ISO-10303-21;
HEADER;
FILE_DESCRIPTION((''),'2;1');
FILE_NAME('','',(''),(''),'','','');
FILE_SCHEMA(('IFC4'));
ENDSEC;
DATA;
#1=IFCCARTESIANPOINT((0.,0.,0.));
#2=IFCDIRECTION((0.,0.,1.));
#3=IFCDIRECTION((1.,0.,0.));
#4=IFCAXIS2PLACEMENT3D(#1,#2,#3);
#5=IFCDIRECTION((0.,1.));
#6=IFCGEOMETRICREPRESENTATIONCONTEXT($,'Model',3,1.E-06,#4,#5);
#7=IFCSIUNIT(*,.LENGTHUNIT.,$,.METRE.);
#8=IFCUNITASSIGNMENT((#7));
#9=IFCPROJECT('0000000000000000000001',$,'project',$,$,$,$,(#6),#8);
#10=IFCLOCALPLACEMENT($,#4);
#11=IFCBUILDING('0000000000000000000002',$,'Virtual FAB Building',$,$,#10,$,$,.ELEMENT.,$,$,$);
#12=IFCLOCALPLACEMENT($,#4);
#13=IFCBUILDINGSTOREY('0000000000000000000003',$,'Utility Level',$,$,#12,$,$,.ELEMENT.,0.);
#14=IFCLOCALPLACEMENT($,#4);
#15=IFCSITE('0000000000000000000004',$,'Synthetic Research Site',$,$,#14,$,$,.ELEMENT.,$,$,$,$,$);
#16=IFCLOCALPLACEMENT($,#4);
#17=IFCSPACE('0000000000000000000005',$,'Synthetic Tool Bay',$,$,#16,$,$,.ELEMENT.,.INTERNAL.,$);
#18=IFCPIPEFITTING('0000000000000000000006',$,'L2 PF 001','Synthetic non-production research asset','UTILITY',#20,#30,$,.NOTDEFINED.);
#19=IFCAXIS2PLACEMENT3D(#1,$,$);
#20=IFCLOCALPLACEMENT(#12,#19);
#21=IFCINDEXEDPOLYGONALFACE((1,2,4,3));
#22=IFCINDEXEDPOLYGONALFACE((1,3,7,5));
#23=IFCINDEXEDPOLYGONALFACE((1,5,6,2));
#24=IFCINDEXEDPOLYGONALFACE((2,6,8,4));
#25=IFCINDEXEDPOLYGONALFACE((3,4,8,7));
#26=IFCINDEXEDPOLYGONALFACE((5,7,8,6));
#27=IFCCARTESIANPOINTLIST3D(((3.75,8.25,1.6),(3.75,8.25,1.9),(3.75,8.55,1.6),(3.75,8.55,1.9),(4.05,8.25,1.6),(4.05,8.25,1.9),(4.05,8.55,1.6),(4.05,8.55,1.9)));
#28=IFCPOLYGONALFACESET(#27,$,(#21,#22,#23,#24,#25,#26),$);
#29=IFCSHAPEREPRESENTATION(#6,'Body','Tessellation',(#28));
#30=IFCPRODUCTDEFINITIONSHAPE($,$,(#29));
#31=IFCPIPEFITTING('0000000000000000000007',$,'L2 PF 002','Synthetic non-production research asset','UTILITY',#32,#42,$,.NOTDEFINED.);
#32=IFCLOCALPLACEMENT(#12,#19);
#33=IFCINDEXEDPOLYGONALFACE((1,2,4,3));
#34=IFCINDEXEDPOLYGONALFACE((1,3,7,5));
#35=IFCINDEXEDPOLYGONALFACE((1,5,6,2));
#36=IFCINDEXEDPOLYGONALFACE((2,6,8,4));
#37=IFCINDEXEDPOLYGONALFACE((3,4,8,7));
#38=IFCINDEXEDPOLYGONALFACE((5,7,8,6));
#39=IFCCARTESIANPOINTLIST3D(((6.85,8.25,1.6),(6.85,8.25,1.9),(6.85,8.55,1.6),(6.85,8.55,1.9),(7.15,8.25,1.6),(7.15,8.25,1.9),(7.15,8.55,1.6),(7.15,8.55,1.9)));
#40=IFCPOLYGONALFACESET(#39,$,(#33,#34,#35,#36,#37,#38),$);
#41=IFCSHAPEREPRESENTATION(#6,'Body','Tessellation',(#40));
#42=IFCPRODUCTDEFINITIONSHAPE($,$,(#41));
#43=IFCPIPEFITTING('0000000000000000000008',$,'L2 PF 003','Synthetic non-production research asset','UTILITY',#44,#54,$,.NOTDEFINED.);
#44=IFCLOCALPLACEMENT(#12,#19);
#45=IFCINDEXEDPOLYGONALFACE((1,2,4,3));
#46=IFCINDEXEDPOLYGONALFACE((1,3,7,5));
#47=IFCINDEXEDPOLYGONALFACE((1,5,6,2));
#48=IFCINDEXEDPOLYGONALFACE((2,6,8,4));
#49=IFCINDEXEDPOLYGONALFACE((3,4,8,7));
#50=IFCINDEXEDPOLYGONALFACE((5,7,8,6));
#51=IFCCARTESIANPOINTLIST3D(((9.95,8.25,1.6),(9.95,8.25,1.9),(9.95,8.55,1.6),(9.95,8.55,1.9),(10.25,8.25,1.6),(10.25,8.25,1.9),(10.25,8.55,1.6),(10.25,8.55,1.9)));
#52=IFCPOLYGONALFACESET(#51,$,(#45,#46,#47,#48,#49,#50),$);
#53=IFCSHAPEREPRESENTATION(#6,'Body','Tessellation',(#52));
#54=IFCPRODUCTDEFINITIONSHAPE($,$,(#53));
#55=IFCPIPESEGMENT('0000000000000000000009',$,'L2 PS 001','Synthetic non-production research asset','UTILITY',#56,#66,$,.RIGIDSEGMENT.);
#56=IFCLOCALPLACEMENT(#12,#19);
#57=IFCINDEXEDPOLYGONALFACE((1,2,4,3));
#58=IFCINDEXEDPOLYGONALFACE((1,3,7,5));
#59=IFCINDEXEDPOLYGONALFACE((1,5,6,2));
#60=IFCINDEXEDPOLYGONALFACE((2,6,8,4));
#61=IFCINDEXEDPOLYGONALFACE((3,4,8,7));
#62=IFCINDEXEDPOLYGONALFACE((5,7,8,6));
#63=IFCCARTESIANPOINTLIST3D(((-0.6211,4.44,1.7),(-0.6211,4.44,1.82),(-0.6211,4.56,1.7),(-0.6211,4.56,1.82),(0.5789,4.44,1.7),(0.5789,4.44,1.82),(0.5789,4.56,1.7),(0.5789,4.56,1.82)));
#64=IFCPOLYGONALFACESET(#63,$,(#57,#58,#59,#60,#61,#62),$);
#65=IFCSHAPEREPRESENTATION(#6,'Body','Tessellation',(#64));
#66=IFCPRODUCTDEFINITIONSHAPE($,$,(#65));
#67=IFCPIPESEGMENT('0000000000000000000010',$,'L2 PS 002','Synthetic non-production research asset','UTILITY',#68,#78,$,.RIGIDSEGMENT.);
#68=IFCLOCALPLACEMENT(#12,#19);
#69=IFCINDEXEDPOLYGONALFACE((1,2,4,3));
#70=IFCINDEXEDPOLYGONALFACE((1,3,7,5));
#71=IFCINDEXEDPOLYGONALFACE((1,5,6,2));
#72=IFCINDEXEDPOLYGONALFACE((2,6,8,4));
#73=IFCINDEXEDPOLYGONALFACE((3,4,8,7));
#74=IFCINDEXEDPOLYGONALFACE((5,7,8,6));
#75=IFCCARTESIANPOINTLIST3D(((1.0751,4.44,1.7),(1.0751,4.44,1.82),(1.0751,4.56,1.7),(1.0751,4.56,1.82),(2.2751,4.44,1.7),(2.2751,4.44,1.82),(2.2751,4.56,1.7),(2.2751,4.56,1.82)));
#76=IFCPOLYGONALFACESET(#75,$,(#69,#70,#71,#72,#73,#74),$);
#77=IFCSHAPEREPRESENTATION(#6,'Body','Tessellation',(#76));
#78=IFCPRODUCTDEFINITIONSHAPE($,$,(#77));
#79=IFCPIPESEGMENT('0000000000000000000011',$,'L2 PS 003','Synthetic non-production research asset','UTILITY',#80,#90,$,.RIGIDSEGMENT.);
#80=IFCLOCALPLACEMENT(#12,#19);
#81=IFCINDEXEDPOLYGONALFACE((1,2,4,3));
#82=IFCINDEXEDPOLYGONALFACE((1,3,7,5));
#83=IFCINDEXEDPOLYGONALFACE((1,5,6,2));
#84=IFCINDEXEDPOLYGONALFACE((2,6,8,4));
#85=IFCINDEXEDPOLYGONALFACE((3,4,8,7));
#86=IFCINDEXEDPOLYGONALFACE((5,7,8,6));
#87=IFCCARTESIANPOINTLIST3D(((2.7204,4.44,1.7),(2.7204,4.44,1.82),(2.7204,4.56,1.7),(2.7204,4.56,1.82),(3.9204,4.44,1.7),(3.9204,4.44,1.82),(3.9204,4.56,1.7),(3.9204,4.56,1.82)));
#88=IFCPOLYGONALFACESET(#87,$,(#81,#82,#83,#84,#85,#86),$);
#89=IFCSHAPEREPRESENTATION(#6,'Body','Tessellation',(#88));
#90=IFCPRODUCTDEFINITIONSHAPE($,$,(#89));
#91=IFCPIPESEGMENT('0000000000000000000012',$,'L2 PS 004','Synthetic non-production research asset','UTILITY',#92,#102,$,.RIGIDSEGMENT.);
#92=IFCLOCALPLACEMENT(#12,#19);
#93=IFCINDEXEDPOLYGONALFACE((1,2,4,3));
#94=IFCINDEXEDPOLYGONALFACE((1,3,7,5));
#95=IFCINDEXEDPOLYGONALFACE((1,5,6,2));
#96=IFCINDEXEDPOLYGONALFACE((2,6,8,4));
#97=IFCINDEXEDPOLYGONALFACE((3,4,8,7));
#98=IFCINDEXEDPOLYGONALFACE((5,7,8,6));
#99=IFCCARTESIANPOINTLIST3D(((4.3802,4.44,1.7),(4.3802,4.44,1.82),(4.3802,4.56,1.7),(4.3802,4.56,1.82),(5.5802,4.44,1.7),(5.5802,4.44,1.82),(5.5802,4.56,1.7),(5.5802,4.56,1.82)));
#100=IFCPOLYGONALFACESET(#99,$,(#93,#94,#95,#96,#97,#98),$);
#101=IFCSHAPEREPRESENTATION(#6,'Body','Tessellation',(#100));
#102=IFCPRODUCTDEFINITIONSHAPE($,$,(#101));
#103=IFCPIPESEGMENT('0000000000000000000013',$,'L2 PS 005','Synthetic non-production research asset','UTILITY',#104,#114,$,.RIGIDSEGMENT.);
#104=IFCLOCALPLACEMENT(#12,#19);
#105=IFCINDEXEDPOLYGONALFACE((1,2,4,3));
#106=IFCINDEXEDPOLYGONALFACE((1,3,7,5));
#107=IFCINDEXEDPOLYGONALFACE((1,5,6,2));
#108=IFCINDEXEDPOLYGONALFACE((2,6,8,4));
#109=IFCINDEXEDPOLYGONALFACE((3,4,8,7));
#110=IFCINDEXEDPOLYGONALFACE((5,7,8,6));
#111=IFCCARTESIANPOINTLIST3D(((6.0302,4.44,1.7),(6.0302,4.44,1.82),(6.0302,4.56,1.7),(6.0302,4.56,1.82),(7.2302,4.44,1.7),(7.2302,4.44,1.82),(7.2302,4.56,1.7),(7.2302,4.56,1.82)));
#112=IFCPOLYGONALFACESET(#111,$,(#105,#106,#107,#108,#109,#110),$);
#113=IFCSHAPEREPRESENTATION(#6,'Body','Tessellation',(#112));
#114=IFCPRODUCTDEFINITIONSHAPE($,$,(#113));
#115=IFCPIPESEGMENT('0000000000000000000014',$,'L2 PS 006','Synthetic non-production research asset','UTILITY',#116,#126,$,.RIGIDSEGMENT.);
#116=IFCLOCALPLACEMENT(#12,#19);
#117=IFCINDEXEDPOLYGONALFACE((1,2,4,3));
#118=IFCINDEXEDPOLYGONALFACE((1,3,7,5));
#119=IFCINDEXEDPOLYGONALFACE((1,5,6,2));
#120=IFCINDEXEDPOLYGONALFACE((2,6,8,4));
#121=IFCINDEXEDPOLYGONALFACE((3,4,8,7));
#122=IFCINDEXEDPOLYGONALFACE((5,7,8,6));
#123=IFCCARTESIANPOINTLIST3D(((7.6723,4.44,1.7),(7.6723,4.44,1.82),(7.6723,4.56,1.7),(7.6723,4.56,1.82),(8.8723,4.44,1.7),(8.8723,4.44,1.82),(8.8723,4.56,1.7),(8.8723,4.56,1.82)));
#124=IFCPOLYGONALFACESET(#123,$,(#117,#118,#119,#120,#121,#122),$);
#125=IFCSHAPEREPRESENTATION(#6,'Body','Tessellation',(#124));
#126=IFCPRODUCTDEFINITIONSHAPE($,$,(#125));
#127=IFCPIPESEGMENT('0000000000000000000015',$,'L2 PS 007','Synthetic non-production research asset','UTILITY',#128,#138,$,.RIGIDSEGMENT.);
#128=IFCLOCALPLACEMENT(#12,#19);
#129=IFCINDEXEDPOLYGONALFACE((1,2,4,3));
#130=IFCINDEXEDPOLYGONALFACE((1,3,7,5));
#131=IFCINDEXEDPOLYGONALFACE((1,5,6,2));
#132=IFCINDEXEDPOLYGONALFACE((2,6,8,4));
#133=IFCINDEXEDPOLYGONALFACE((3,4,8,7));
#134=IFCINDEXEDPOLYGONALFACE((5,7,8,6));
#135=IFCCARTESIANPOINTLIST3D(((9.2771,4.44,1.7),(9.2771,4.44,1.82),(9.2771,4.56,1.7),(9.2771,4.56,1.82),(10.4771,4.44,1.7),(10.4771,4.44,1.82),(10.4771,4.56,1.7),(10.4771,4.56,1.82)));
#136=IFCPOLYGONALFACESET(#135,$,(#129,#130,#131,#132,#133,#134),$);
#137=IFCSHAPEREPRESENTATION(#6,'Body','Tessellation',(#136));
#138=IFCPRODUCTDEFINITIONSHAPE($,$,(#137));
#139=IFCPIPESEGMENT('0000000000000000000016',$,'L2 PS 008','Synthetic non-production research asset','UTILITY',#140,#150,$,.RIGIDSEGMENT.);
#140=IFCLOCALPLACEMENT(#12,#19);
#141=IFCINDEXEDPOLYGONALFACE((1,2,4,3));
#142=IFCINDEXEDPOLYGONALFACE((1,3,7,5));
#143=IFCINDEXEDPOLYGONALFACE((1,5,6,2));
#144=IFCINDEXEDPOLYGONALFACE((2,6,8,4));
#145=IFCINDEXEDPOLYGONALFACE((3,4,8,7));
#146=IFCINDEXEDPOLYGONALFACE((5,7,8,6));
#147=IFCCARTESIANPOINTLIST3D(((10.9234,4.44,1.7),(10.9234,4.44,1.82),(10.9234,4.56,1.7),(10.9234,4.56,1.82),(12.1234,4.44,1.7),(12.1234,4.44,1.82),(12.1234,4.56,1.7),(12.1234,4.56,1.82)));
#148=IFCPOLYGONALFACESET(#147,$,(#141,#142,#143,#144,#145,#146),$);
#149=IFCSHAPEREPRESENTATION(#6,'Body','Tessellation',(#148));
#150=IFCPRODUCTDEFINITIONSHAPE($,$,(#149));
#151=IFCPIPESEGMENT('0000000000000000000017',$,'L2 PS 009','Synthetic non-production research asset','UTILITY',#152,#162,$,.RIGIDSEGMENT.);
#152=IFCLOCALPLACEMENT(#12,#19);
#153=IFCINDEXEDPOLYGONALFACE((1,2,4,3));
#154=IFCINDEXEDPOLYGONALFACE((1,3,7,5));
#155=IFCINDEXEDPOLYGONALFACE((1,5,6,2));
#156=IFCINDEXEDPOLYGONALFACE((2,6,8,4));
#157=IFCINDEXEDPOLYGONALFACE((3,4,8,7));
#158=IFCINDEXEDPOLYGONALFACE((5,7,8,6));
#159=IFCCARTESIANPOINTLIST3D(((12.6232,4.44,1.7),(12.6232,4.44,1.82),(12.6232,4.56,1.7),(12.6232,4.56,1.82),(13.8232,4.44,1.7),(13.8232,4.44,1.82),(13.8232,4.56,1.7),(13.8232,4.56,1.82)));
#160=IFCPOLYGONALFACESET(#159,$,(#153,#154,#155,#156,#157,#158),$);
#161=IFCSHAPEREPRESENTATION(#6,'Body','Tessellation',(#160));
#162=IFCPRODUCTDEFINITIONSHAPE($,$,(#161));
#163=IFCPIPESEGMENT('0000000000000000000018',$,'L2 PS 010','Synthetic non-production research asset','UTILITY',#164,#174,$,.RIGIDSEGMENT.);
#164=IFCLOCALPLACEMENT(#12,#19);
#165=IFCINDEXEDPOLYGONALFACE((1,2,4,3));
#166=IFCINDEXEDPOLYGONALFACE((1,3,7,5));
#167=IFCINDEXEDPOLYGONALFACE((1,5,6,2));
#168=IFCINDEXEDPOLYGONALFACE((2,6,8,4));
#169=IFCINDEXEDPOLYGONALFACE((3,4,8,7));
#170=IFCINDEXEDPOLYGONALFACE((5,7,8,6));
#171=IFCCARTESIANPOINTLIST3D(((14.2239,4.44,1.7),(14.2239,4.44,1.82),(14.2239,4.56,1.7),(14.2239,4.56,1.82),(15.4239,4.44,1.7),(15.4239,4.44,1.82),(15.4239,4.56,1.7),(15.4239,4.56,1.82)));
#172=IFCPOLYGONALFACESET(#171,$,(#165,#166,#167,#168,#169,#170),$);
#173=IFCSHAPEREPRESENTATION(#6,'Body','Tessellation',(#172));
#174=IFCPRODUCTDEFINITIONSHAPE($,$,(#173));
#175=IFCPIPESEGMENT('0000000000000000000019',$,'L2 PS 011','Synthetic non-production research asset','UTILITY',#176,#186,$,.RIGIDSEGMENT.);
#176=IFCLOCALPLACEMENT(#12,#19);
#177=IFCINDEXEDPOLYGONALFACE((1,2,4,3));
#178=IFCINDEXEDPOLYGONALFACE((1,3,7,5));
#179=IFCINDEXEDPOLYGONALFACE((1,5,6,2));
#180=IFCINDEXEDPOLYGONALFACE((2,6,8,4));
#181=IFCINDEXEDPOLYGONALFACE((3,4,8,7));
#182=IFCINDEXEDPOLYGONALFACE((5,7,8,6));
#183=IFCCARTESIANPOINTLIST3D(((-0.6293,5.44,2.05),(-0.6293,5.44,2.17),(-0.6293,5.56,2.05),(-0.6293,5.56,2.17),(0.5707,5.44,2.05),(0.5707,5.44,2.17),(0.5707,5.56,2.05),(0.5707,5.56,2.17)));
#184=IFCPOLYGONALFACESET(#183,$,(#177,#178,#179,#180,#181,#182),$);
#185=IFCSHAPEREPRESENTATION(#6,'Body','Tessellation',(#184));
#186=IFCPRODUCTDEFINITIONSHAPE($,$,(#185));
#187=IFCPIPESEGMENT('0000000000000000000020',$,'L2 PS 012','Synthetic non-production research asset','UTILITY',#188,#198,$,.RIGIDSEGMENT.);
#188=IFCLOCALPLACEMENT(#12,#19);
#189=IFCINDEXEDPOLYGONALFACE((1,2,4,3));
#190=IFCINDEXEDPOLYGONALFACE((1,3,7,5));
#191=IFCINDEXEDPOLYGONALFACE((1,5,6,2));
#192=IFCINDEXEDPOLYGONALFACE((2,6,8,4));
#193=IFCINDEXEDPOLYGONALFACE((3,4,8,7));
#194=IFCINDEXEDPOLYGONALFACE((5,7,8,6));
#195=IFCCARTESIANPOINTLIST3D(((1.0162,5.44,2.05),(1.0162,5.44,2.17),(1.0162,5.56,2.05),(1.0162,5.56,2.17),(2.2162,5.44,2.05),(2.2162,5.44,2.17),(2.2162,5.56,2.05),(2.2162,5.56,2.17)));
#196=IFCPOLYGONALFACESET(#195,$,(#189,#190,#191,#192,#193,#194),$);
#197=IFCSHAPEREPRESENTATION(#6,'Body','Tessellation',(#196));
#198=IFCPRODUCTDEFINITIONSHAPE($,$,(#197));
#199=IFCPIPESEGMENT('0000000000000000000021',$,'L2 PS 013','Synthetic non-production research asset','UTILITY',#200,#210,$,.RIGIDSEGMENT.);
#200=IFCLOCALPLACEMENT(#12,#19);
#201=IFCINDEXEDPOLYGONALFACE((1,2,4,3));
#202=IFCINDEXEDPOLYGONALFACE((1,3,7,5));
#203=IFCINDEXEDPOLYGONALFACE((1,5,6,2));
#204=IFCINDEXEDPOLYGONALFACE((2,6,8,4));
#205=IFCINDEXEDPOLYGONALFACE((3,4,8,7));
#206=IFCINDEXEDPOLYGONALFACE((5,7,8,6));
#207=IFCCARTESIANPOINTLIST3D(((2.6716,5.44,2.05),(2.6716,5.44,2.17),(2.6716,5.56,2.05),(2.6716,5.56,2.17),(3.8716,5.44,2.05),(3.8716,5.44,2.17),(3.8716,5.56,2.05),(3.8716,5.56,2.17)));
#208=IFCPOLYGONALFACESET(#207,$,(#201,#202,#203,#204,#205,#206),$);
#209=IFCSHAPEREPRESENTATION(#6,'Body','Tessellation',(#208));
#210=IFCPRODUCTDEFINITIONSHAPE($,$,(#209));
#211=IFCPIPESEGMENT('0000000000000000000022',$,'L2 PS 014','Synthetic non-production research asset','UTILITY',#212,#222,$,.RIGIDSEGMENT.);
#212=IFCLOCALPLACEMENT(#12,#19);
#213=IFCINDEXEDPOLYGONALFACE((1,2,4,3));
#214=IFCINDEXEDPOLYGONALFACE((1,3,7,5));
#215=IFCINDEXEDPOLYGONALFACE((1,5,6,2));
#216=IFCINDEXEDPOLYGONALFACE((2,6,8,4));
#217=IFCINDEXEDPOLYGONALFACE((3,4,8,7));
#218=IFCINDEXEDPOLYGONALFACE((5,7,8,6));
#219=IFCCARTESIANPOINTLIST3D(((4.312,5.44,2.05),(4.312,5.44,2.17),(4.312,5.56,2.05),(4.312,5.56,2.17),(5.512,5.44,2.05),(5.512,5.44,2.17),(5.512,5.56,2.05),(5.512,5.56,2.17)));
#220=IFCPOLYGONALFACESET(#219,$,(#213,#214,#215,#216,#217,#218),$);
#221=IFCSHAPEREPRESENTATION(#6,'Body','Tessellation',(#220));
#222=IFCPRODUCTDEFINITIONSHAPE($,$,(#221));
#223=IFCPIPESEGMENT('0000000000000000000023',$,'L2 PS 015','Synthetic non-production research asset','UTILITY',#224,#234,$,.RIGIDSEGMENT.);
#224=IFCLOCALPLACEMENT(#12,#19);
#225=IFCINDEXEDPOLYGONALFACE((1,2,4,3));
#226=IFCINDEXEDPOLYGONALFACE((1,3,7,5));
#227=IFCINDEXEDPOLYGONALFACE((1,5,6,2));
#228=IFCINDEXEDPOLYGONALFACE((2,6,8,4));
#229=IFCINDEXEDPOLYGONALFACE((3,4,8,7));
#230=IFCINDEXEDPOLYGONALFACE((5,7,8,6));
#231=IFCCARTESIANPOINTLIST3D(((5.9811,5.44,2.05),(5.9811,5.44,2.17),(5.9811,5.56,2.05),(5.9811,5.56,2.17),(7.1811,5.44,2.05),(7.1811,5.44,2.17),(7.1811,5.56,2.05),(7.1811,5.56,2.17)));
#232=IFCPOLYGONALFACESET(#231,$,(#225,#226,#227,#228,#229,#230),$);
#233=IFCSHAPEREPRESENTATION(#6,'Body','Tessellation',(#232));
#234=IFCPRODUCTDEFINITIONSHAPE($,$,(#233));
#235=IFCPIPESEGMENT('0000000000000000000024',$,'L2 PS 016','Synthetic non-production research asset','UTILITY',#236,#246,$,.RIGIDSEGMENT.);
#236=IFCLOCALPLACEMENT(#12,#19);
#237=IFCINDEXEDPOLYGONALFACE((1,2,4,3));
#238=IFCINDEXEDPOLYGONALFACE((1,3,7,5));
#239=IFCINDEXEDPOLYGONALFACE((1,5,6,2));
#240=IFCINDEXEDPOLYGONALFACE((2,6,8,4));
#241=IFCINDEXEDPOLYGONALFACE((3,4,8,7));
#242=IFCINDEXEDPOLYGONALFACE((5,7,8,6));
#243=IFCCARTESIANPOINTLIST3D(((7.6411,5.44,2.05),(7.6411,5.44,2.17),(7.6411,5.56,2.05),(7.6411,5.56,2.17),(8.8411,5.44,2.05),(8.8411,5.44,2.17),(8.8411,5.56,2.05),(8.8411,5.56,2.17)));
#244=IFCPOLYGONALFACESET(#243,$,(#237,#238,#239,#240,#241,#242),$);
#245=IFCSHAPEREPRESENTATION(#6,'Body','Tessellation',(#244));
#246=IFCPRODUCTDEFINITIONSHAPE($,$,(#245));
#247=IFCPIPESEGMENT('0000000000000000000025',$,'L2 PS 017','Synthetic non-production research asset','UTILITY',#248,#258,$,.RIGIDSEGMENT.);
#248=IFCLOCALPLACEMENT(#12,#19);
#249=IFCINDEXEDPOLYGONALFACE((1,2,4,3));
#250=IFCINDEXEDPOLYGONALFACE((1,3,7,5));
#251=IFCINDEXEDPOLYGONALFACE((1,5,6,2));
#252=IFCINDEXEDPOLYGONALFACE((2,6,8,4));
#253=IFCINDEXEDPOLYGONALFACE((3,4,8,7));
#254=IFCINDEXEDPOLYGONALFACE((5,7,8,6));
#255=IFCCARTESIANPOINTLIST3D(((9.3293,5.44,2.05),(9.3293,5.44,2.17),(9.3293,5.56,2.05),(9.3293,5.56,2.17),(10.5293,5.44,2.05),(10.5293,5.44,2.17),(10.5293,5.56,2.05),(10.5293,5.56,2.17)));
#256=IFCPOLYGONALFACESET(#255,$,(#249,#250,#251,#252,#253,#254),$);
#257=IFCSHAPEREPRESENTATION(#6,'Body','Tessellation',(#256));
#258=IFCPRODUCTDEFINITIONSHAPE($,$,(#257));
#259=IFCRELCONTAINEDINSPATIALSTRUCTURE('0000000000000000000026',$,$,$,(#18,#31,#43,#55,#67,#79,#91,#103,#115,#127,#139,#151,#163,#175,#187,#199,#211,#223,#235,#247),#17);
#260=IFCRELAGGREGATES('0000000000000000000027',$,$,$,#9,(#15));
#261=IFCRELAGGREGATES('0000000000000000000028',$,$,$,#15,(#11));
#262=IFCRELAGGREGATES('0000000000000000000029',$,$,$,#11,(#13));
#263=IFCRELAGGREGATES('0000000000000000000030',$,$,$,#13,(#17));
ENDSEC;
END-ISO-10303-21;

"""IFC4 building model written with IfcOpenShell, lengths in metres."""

from ifc_helpers import new_model, si_unit, direction, frame, origin_with_axes, origin_2d_with_axis, place, context, project, spatial, rectangle, extrude, element, save


model = new_model("IFC4")

# Units and contexts
model_context = context("Model", 3, precision=1e-06, world=origin_with_axes(), true_north=direction((0.0, 1.0)))
ifc_project = project(units=[si_unit("LENGTHUNIT", "METRE")], contexts=[model_context])

# Site, building, storey, space
site_placement = place(None, origin_with_axes())
site = spatial("IfcSite", under=ifc_project, at=site_placement, Name="Synthetic Research Site", CompositionType="ELEMENT")
building_placement = place(None, origin_with_axes())
building = spatial("IfcBuilding", under=site, at=building_placement, Name="Virtual FAB Building", CompositionType="ELEMENT")
storey_placement = place(None, origin_with_axes())
storey = spatial("IfcBuildingStorey", under=building, at=storey_placement, Name="Utility Level", CompositionType="ELEMENT", Elevation=0.0)
space_placement = place(None, origin_with_axes())
space = spatial("IfcSpace", under=storey, at=space_placement, Name="Synthetic Tool Bay", CompositionType="ELEMENT", PredefinedType="INTERNAL")

# Pipe fittings
for number, where, z_axis, x_axis, name in (
    (1, (3.9, 8.4, 1.6), (0.0, 0.0, 1.0), (1.0, 0.0, 0.0), "L2 PF 001"),
    (2, (7.0, 8.4, 1.6), (0.0, 0.0, 1.0), (1.0, 0.0, 0.0), "L2 PF 002"),
    (3, (10.1, 8.4, 1.6), (0.0, 0.0, 1.0), (1.0, 0.0, 0.0), "L2 PF 003"),
):
    element("IfcPipeFitting", number, at=place(None, frame(where, z_axis=z_axis, x_axis=x_axis)), inside=space, Name=name, Description="Synthetic non-production research asset", ObjectType="UTILITY", PredefinedType="NOTDEFINED", context=model_context, shape_type="SweptSolid", body=[
        extrude(rectangle(XDim=0.3, YDim=0.3, at=origin_2d_with_axis()), origin_with_axes(), (0.0, 0.0, 1.0), 0.3),
    ])

# Pipe segments
for number, where, z_axis, x_axis, name in (
    (4, (-0.0211, 4.5, 1.7), (0.0, 0.0, 1.0), (1.0, 0.0, 0.0), "L2 PS 001"),
    (5, (1.6751, 4.5, 1.7), (0.0, 0.0, 1.0), (1.0, 0.0, 0.0), "L2 PS 002"),
    (6, (3.3204, 4.5, 1.7), (0.0, 0.0, 1.0), (1.0, 0.0, 0.0), "L2 PS 003"),
    (7, (4.9802, 4.5, 1.7), (0.0, 0.0, 1.0), (1.0, 0.0, 0.0), "L2 PS 004"),
    (8, (6.6302, 4.5, 1.7), (0.0, 0.0, 1.0), (1.0, 0.0, 0.0), "L2 PS 005"),
    (9, (8.2723, 4.5, 1.7), (0.0, 0.0, 1.0), (1.0, 0.0, 0.0), "L2 PS 006"),
    (10, (9.8771, 4.5, 1.7), (0.0, 0.0, 1.0), (1.0, 0.0, 0.0), "L2 PS 007"),
    (11, (11.5234, 4.5, 1.7), (0.0, 0.0, 1.0), (1.0, 0.0, 0.0), "L2 PS 008"),
    (12, (13.2232, 4.5, 1.7), (0.0, 0.0, 1.0), (1.0, 0.0, 0.0), "L2 PS 009"),
    (13, (14.8239, 4.5, 1.7), (0.0, 0.0, 1.0), (1.0, 0.0, 0.0), "L2 PS 010"),
    (14, (-0.0293, 5.5, 2.05), (0.0, 0.0, 1.0), (1.0, 0.0, 0.0), "L2 PS 011"),
    (15, (1.6162, 5.5, 2.05), (0.0, 0.0, 1.0), (1.0, 0.0, 0.0), "L2 PS 012"),
    (16, (3.2716, 5.5, 2.05), (0.0, 0.0, 1.0), (1.0, 0.0, 0.0), "L2 PS 013"),
    (17, (4.912, 5.5, 2.05), (0.0, 0.0, 1.0), (1.0, 0.0, 0.0), "L2 PS 014"),
    (18, (6.5811, 5.5, 2.05), (0.0, 0.0, 1.0), (1.0, 0.0, 0.0), "L2 PS 015"),
    (19, (8.2411, 5.5, 2.05), (0.0, 0.0, 1.0), (1.0, 0.0, 0.0), "L2 PS 016"),
    (20, (9.9293, 5.5, 2.05), (0.0, 0.0, 1.0), (1.0, 0.0, 0.0), "L2 PS 017"),
):
    element("IfcPipeSegment", number, at=place(None, frame(where, z_axis=z_axis, x_axis=x_axis)), inside=space, Name=name, Description="Synthetic non-production research asset", ObjectType="UTILITY", PredefinedType="RIGIDSEGMENT", context=model_context, shape_type="SweptSolid", body=[
        extrude(rectangle(XDim=1.2, YDim=0.12, at=origin_2d_with_axis()), origin_with_axes(), (0.0, 0.0, 1.0), 0.12),
    ])

save(model, "model.ifc")
